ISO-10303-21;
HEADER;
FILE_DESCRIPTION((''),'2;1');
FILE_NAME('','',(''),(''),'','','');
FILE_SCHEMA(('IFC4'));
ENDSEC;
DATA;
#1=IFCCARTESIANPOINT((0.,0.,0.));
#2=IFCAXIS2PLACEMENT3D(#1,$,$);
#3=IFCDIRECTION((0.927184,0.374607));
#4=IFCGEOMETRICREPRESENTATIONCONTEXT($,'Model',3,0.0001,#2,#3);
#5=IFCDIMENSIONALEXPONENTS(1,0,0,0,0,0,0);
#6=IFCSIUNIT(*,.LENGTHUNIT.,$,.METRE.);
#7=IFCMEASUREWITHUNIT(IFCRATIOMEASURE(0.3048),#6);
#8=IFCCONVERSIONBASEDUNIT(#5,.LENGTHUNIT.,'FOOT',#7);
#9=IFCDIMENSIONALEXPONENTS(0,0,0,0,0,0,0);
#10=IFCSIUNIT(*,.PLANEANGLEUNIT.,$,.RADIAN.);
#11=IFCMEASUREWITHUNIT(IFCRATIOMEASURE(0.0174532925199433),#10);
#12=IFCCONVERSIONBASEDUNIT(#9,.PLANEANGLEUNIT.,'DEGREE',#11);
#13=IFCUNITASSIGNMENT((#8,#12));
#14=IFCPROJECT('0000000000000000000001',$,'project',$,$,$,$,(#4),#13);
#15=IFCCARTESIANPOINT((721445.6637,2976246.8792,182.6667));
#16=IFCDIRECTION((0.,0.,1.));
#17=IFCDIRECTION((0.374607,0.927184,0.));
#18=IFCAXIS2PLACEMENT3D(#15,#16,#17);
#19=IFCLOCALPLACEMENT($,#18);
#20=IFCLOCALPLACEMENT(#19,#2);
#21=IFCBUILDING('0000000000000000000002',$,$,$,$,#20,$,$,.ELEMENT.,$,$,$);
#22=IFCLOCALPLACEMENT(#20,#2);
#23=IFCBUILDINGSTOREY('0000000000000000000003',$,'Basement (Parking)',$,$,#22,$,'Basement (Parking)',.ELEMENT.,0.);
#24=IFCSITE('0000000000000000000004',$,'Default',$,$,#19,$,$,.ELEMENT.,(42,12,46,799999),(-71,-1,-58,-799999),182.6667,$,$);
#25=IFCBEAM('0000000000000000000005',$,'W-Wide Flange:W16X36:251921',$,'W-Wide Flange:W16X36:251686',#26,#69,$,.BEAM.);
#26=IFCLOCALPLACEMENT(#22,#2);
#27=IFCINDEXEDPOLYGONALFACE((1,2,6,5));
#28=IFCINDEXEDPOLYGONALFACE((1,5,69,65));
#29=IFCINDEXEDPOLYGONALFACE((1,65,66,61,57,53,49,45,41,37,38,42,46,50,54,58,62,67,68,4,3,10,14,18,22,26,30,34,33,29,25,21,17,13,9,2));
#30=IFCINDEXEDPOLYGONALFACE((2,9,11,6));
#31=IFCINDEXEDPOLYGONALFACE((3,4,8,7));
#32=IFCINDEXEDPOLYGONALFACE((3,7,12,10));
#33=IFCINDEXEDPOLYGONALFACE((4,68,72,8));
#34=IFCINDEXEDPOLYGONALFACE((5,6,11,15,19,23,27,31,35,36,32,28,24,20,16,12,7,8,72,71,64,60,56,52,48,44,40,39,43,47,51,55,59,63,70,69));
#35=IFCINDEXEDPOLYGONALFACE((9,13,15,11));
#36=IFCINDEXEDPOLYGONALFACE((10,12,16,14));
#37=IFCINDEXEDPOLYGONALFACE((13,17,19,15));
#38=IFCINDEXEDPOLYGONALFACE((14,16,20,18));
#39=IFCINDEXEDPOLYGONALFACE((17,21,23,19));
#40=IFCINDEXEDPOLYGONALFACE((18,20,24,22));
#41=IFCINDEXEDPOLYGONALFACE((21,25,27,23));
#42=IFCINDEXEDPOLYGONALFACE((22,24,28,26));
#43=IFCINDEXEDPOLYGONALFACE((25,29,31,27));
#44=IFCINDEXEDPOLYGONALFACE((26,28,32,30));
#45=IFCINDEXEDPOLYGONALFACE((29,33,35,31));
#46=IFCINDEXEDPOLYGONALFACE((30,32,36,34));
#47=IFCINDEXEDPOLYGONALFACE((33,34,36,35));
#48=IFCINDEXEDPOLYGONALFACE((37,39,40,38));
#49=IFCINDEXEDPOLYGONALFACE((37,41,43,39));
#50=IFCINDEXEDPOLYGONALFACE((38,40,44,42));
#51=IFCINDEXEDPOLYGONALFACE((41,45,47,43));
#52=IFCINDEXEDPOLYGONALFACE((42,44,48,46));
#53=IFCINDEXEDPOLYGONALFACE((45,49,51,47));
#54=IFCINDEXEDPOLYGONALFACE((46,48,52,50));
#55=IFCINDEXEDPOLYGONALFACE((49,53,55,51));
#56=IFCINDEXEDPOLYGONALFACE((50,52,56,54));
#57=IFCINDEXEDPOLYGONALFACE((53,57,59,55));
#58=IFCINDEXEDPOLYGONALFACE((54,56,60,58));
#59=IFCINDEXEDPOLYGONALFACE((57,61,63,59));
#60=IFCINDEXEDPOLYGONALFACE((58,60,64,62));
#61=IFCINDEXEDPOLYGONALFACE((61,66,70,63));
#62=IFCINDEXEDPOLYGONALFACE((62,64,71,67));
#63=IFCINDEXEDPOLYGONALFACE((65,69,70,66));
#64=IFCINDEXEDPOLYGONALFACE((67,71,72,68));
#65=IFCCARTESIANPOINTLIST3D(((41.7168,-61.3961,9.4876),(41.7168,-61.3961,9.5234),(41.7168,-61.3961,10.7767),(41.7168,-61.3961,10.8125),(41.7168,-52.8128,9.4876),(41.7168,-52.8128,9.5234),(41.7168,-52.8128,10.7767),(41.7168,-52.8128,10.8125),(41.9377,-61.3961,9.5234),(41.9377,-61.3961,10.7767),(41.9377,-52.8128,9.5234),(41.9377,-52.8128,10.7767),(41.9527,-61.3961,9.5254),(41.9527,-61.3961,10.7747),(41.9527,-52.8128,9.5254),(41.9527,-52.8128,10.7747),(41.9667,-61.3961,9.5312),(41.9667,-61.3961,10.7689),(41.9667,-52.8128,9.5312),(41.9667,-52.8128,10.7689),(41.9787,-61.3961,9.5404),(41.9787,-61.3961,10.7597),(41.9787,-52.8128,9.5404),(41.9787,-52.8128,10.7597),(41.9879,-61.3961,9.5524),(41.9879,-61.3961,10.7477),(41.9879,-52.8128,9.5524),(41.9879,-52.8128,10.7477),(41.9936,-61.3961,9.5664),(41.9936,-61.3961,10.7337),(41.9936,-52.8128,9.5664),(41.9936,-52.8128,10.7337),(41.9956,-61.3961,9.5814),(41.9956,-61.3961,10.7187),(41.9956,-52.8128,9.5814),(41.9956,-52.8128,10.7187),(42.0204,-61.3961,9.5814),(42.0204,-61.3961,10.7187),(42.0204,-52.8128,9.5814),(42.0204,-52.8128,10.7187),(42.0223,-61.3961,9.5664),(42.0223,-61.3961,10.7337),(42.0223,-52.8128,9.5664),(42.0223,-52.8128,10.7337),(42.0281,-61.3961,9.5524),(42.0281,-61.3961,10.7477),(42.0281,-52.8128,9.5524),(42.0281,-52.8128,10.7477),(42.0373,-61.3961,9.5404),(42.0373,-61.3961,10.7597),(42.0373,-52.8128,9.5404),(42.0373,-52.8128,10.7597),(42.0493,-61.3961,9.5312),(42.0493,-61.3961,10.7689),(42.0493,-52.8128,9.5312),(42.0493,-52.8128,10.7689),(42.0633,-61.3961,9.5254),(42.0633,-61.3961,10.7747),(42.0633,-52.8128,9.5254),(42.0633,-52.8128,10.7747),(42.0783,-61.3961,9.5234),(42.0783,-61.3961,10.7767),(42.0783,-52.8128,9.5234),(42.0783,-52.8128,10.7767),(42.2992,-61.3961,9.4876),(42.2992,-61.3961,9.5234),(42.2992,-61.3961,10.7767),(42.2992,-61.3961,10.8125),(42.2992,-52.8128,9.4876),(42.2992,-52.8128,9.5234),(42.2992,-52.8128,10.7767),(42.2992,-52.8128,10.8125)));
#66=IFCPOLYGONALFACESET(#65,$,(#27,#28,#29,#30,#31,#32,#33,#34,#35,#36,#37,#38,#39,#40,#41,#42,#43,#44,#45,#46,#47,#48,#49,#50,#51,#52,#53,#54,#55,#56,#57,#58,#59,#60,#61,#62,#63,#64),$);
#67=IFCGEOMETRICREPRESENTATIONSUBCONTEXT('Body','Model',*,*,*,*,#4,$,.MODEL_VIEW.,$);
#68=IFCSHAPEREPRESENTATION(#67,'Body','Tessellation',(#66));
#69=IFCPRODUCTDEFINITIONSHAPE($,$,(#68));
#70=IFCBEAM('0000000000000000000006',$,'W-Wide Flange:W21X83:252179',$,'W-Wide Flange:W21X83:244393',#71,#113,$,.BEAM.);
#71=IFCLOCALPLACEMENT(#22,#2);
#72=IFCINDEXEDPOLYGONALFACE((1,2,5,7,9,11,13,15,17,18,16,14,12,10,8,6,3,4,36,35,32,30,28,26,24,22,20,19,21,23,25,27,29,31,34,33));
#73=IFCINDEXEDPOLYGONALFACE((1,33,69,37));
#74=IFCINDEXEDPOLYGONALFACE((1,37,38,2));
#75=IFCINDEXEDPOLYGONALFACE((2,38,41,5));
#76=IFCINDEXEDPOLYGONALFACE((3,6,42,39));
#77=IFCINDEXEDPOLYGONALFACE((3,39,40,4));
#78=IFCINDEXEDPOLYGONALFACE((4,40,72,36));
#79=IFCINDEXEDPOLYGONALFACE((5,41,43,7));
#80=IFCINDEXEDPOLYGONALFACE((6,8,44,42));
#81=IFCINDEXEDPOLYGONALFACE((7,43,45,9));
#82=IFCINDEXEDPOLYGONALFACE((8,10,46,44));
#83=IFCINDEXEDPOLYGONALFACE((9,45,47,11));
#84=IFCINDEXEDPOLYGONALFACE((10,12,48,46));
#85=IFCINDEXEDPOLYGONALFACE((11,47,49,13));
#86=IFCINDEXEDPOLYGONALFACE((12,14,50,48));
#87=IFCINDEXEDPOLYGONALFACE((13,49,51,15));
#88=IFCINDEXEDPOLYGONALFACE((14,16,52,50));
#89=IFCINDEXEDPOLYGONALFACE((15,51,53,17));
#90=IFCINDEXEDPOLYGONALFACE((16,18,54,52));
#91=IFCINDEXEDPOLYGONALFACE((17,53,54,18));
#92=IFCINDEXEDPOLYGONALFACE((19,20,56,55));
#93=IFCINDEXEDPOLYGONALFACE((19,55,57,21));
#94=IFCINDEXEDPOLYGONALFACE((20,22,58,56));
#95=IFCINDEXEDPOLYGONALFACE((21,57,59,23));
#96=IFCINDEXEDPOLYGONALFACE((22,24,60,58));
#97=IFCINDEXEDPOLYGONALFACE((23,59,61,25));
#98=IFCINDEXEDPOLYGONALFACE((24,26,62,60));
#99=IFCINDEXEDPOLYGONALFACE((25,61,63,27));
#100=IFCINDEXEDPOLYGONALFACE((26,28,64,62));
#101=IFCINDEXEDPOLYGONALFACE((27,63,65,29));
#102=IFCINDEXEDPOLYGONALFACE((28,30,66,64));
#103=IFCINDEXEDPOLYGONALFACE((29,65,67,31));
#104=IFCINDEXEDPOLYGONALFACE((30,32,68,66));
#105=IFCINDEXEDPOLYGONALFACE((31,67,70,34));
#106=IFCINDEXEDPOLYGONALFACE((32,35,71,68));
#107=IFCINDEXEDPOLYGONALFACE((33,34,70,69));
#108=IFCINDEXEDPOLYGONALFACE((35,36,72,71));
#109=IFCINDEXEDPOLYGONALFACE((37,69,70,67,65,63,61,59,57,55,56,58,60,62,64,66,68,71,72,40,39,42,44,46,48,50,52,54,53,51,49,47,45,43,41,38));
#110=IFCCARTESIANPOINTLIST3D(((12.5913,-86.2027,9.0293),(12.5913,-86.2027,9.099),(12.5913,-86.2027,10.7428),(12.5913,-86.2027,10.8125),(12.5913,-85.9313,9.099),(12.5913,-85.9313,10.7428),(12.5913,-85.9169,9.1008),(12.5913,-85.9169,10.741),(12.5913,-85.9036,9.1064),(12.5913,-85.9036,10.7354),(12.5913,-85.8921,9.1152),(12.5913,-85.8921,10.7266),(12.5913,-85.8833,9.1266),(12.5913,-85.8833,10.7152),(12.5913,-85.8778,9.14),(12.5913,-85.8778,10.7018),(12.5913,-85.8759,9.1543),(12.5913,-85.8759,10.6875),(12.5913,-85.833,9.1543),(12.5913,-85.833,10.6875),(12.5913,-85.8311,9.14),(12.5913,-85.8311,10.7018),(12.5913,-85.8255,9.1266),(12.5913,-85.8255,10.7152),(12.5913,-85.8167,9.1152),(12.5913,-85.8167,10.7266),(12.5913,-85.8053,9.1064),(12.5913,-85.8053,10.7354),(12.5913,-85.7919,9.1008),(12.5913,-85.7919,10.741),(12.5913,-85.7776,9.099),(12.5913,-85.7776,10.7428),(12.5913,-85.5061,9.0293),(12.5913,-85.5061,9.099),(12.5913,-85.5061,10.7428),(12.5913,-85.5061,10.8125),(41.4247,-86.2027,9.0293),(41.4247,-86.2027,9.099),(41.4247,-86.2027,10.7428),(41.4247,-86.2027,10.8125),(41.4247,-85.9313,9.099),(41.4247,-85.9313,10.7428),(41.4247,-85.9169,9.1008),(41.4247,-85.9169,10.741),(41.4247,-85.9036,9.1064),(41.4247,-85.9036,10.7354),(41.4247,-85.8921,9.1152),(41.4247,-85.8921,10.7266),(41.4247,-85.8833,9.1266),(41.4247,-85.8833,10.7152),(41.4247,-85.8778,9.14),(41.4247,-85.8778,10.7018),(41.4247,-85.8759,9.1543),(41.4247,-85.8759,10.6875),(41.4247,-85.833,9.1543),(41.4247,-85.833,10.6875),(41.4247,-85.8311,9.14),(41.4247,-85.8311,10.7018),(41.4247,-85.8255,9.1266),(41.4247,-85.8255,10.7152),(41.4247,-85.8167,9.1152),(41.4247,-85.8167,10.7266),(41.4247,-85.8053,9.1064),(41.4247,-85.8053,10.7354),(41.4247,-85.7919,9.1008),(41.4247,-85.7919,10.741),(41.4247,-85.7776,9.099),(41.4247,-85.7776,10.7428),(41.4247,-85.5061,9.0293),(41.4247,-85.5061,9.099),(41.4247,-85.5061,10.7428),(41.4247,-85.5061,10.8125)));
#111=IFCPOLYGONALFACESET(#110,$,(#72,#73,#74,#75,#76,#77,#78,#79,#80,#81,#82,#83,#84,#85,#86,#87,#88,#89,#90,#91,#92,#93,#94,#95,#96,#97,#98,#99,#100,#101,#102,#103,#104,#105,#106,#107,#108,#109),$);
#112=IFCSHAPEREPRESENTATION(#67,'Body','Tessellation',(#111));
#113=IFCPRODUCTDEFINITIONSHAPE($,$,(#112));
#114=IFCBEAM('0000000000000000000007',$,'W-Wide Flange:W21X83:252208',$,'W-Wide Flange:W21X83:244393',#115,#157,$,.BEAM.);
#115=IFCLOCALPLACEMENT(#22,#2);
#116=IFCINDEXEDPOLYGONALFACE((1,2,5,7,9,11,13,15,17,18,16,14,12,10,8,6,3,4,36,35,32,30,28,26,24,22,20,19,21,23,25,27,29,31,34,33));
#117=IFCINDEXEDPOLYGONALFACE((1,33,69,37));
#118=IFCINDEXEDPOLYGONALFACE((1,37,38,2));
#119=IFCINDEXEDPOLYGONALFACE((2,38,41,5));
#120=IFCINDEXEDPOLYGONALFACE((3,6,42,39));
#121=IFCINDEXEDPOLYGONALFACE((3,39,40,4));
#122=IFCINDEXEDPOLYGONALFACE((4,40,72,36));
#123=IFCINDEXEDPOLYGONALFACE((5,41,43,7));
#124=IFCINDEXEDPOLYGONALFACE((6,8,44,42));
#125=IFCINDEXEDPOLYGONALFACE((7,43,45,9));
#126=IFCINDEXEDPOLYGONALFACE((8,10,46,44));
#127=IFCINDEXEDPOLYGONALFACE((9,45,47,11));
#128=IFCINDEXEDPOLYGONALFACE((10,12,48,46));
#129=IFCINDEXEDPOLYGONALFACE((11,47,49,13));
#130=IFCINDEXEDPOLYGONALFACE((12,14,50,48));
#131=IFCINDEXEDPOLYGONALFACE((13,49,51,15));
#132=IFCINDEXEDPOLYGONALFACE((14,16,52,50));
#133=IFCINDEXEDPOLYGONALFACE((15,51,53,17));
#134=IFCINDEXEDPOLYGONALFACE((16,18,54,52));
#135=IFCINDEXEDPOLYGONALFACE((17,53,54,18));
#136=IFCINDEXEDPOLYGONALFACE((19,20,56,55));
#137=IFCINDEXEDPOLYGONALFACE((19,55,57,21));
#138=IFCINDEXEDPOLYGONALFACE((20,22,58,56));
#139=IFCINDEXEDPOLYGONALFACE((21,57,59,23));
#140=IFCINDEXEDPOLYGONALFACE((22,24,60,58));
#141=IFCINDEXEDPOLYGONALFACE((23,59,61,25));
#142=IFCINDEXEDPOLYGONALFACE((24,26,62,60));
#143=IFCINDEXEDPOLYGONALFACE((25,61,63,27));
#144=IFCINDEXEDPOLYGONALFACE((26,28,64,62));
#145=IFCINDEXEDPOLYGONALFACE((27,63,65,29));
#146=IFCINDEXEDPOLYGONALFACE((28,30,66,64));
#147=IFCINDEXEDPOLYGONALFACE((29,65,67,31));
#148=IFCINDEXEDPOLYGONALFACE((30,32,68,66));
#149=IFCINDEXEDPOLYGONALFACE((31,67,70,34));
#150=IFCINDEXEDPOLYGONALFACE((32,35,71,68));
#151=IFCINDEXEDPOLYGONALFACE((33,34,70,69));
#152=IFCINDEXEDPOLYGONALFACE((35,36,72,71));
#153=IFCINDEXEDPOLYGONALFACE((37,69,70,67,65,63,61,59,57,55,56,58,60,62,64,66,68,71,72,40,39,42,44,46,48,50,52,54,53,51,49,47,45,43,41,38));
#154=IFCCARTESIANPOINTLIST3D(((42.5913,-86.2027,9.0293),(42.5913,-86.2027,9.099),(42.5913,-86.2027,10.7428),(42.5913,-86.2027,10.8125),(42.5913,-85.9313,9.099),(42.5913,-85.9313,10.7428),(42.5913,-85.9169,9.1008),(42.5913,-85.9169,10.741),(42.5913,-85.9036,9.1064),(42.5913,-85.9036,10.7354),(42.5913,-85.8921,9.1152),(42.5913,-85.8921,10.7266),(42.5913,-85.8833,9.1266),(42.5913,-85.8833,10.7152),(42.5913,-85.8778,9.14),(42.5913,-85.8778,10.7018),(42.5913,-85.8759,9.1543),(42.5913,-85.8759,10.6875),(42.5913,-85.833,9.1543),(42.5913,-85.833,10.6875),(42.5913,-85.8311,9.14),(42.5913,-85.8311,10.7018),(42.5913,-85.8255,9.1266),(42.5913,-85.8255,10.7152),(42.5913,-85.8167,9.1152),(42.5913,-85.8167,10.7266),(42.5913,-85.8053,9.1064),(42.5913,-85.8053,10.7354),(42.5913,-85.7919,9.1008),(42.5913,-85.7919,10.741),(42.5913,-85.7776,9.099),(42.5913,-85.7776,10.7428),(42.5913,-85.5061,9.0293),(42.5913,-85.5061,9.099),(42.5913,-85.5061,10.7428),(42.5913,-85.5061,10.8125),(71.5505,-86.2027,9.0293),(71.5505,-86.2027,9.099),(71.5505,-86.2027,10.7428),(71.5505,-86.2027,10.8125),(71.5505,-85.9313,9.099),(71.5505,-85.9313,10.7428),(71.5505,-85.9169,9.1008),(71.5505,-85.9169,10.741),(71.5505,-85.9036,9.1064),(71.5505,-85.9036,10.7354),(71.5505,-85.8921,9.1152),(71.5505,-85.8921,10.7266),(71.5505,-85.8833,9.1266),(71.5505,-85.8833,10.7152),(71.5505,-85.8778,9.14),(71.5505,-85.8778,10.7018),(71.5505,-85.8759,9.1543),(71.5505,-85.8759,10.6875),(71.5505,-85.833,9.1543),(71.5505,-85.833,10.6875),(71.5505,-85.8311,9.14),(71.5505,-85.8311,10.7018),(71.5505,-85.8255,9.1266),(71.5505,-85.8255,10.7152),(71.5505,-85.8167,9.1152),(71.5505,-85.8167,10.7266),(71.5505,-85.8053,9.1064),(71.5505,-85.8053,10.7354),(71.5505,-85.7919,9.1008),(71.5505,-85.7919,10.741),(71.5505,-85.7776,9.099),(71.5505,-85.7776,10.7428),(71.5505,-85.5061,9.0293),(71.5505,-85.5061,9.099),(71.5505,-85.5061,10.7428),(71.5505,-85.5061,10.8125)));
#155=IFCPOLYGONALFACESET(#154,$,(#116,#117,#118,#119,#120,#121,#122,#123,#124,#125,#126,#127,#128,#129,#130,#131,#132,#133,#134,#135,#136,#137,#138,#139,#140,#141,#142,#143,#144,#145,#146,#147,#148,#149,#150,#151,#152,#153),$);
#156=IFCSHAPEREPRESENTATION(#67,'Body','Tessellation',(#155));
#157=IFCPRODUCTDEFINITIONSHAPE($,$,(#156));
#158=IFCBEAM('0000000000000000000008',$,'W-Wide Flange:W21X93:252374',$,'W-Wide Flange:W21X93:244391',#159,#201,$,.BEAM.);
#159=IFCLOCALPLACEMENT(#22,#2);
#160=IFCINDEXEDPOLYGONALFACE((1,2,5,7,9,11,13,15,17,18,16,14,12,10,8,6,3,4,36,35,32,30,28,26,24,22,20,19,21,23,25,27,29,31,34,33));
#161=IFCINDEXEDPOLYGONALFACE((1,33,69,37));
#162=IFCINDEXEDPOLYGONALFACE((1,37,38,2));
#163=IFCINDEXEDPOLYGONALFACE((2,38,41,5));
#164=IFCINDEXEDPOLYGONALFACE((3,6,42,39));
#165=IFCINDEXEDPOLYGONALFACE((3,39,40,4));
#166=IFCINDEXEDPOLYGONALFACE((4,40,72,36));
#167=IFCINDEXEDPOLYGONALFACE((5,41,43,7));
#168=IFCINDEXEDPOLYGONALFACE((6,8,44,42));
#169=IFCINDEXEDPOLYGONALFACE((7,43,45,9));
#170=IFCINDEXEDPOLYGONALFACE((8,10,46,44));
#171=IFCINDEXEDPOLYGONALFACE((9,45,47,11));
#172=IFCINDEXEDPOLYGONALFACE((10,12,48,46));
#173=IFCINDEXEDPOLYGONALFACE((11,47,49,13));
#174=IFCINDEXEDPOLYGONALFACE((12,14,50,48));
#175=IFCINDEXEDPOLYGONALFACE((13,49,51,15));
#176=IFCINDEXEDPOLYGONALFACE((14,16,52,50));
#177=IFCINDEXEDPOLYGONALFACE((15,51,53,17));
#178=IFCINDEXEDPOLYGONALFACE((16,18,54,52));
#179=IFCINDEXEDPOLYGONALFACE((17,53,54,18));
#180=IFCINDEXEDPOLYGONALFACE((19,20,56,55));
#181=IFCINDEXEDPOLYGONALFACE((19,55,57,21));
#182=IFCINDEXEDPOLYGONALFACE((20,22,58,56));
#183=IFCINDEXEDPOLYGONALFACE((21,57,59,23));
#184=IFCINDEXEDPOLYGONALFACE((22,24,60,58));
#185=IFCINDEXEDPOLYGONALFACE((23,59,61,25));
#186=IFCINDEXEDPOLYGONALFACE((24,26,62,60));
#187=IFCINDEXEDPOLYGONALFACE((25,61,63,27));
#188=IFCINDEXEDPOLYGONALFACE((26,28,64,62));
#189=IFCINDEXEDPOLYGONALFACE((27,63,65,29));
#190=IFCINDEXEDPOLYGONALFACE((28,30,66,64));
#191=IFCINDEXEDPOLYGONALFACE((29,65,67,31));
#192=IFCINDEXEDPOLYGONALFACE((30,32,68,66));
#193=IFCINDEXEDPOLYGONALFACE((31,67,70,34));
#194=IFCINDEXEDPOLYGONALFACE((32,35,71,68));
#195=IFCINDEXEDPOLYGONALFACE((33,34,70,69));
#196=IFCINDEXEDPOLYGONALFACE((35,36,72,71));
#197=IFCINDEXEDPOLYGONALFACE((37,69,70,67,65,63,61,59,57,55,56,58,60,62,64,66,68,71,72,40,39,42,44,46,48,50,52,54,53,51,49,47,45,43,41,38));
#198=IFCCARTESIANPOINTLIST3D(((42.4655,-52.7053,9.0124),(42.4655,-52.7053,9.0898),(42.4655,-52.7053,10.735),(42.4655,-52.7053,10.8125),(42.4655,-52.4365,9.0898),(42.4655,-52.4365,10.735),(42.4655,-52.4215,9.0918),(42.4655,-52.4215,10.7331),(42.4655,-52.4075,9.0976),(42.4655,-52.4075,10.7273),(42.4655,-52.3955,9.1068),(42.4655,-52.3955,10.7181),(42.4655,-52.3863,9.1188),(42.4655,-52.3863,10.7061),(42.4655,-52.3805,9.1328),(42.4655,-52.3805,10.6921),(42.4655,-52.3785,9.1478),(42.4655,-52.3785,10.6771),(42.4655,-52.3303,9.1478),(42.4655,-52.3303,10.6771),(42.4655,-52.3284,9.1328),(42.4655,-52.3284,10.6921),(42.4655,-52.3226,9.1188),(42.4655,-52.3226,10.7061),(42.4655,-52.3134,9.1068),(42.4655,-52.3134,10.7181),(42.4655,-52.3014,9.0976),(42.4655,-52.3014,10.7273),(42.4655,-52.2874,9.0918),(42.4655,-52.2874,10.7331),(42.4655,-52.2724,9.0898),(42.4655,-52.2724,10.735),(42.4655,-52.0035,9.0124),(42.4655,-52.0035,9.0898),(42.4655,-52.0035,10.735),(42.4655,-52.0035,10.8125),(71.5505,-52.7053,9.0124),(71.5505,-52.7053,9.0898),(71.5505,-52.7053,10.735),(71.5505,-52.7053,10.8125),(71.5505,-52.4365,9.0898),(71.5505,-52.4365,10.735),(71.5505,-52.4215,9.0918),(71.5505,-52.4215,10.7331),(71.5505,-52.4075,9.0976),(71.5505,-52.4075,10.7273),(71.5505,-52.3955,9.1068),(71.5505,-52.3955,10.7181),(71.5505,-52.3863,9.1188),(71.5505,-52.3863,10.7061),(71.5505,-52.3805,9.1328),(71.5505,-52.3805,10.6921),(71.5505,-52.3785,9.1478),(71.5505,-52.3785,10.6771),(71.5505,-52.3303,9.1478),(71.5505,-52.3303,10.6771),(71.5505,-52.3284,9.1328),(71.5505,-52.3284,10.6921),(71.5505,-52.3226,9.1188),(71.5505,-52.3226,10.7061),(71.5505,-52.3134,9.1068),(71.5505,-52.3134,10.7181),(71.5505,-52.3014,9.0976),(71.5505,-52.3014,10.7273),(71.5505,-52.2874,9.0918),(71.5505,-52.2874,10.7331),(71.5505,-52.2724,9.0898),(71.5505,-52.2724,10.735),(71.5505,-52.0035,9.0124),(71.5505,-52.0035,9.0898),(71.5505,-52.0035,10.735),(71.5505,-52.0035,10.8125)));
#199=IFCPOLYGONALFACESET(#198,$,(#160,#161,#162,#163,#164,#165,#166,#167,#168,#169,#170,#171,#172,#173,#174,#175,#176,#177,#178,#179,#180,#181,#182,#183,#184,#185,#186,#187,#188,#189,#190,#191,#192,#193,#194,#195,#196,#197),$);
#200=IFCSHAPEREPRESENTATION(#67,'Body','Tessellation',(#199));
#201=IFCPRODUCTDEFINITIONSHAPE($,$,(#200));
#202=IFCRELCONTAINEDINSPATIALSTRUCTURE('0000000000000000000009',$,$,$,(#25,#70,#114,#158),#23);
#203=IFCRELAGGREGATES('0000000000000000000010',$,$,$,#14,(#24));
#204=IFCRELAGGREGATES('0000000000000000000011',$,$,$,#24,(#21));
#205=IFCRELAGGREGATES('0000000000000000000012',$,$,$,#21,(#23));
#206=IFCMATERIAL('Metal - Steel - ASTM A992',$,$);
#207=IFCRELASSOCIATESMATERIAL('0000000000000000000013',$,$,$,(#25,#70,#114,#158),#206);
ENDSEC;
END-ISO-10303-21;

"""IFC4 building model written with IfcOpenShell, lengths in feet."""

from ifc_helpers import new_model, entity, si_unit, converted_unit, direction, frame, frame_2d, origin, place, context, subcontext, project, spatial, i_section, extrude, material, element, save


model = new_model("IFC4")

# Units and contexts
model_context = context("Model", 3, precision=0.0001, world=origin(), true_north=direction((0.927184, 0.374607)))
body_context = subcontext(model_context, "Body", "Model", "MODEL_VIEW")
ifc_project = project(units=[converted_unit("LENGTHUNIT", "FOOT", entity("IfcRatioMeasure", 0.3048), si_unit("LENGTHUNIT", "METRE"), dimensions=[1, 0, 0, 0, 0, 0, 0]), converted_unit("PLANEANGLEUNIT", "DEGREE", entity("IfcRatioMeasure", 0.0174532925199433), si_unit("PLANEANGLEUNIT", "RADIAN"), dimensions=[0, 0, 0, 0, 0, 0, 0])], contexts=[model_context])

# Site, building, storey
site_placement = place(None, frame((721445.6637, 2976246.8792, 182.6667), z_axis=(0.0, 0.0, 1.0), x_axis=(0.374607, 0.927184, 0.0)))
site = spatial("IfcSite", under=ifc_project, at=site_placement, Name="Default", CompositionType="ELEMENT", RefLatitude=(42, 12, 46, 799999), RefLongitude=(-71, -1, -58, -799999), RefElevation=182.6667)
building_placement = place(site_placement, origin())
building = spatial("IfcBuilding", under=site, at=building_placement, CompositionType="ELEMENT")
storey_placement = place(building_placement, origin())
storey = spatial("IfcBuildingStorey", under=building, at=storey_placement, Name="Basement (Parking)", LongName="Basement (Parking)", CompositionType="ELEMENT", Elevation=0.0)

# Shared definitions
ifc_material_1 = material(Name="Metal - Steel - ASTM A992")

# Beams
beam_1_placement = place(storey_placement, frame((42.008, -61.3961, 10.8125), z_axis=(0.0, 0.0, 1.0), x_axis=(0.0, 1.0, 0.0)))
element("IfcBeam", 1, at=beam_1_placement, inside=storey, material=ifc_material_1, Name="W-Wide Flange:W16X36:251921", ObjectType="W-Wide Flange:W16X36:251686", PredefinedType="BEAM", context=body_context, shape_type="SweptSolid", body=[
    extrude(i_section(OverallWidth=0.5824, OverallDepth=1.3249, WebThickness=0.0247, FlangeThickness=0.0358, FilletRadius=0.0579, at=frame_2d((0.0, 0.0), x_axis=(0.0, 1.0))), frame((0.0, 0.0, -0.6624), z_axis=(1.0, 0.0, 0.0), x_axis=(0.0, 0.0, -1.0)), (0.0, 0.0, 1.0), 8.5833),
])
beam_2_placement = place(storey_placement, frame((12.008, -85.8544, 10.8125)))
element("IfcBeam", 2, at=beam_2_placement, inside=storey, material=ifc_material_1, Name="W-Wide Flange:W21X83:252179", ObjectType="W-Wide Flange:W21X83:244393", PredefinedType="BEAM", context=body_context, shape_type="SweptSolid", body=[
    extrude(i_section(OverallWidth=0.6966, OverallDepth=1.7832, WebThickness=0.043, FlangeThickness=0.0697, FilletRadius=0.0553, at=frame_2d((0.0, 0.0), x_axis=(0.0, 1.0))), frame((0.5833, 0.0, -0.8916), z_axis=(1.0, 0.0, 0.0), x_axis=(0.0, 0.0, -1.0)), (0.0, 0.0, 1.0), 28.8333),
])
beam_3_placement = place(storey_placement, frame((42.008, -85.8544, 10.8125)))
element("IfcBeam", 3, at=beam_3_placement, inside=storey, material=ifc_material_1, Name="W-Wide Flange:W21X83:252208", ObjectType="W-Wide Flange:W21X83:244393", PredefinedType="BEAM", context=body_context, shape_type="SweptSolid", body=[
    extrude(i_section(OverallWidth=0.6966, OverallDepth=1.7832, WebThickness=0.043, FlangeThickness=0.0697, FilletRadius=0.0553, at=frame_2d((0.0, 0.0), x_axis=(0.0, 1.0))), frame((0.5833, 0.0, -0.8916), z_axis=(1.0, 0.0, 0.0), x_axis=(0.0, 0.0, -1.0)), (0.0, 0.0, 1.0), 28.9591),
])
beam_4_placement = place(storey_placement, frame((42.008, -52.3544, 10.8125)))
element("IfcBeam", 4, at=beam_4_placement, inside=storey, material=ifc_material_1, Name="W-Wide Flange:W21X93:252374", ObjectType="W-Wide Flange:W21X93:244391", PredefinedType="BEAM", context=body_context, shape_type="SweptSolid", body=[
    extrude(i_section(OverallWidth=0.7018, OverallDepth=1.8001, WebThickness=0.0482, FlangeThickness=0.0775, FilletRadius=0.0579, at=frame_2d((0.0, 0.0), x_axis=(0.0, 1.0))), frame((0.4575, 0.0, -0.9001), z_axis=(1.0, 0.0, 0.0), x_axis=(0.0, 0.0, -1.0)), (0.0, 0.0, 1.0), 29.085),
])

save(model, "model.ifc")
